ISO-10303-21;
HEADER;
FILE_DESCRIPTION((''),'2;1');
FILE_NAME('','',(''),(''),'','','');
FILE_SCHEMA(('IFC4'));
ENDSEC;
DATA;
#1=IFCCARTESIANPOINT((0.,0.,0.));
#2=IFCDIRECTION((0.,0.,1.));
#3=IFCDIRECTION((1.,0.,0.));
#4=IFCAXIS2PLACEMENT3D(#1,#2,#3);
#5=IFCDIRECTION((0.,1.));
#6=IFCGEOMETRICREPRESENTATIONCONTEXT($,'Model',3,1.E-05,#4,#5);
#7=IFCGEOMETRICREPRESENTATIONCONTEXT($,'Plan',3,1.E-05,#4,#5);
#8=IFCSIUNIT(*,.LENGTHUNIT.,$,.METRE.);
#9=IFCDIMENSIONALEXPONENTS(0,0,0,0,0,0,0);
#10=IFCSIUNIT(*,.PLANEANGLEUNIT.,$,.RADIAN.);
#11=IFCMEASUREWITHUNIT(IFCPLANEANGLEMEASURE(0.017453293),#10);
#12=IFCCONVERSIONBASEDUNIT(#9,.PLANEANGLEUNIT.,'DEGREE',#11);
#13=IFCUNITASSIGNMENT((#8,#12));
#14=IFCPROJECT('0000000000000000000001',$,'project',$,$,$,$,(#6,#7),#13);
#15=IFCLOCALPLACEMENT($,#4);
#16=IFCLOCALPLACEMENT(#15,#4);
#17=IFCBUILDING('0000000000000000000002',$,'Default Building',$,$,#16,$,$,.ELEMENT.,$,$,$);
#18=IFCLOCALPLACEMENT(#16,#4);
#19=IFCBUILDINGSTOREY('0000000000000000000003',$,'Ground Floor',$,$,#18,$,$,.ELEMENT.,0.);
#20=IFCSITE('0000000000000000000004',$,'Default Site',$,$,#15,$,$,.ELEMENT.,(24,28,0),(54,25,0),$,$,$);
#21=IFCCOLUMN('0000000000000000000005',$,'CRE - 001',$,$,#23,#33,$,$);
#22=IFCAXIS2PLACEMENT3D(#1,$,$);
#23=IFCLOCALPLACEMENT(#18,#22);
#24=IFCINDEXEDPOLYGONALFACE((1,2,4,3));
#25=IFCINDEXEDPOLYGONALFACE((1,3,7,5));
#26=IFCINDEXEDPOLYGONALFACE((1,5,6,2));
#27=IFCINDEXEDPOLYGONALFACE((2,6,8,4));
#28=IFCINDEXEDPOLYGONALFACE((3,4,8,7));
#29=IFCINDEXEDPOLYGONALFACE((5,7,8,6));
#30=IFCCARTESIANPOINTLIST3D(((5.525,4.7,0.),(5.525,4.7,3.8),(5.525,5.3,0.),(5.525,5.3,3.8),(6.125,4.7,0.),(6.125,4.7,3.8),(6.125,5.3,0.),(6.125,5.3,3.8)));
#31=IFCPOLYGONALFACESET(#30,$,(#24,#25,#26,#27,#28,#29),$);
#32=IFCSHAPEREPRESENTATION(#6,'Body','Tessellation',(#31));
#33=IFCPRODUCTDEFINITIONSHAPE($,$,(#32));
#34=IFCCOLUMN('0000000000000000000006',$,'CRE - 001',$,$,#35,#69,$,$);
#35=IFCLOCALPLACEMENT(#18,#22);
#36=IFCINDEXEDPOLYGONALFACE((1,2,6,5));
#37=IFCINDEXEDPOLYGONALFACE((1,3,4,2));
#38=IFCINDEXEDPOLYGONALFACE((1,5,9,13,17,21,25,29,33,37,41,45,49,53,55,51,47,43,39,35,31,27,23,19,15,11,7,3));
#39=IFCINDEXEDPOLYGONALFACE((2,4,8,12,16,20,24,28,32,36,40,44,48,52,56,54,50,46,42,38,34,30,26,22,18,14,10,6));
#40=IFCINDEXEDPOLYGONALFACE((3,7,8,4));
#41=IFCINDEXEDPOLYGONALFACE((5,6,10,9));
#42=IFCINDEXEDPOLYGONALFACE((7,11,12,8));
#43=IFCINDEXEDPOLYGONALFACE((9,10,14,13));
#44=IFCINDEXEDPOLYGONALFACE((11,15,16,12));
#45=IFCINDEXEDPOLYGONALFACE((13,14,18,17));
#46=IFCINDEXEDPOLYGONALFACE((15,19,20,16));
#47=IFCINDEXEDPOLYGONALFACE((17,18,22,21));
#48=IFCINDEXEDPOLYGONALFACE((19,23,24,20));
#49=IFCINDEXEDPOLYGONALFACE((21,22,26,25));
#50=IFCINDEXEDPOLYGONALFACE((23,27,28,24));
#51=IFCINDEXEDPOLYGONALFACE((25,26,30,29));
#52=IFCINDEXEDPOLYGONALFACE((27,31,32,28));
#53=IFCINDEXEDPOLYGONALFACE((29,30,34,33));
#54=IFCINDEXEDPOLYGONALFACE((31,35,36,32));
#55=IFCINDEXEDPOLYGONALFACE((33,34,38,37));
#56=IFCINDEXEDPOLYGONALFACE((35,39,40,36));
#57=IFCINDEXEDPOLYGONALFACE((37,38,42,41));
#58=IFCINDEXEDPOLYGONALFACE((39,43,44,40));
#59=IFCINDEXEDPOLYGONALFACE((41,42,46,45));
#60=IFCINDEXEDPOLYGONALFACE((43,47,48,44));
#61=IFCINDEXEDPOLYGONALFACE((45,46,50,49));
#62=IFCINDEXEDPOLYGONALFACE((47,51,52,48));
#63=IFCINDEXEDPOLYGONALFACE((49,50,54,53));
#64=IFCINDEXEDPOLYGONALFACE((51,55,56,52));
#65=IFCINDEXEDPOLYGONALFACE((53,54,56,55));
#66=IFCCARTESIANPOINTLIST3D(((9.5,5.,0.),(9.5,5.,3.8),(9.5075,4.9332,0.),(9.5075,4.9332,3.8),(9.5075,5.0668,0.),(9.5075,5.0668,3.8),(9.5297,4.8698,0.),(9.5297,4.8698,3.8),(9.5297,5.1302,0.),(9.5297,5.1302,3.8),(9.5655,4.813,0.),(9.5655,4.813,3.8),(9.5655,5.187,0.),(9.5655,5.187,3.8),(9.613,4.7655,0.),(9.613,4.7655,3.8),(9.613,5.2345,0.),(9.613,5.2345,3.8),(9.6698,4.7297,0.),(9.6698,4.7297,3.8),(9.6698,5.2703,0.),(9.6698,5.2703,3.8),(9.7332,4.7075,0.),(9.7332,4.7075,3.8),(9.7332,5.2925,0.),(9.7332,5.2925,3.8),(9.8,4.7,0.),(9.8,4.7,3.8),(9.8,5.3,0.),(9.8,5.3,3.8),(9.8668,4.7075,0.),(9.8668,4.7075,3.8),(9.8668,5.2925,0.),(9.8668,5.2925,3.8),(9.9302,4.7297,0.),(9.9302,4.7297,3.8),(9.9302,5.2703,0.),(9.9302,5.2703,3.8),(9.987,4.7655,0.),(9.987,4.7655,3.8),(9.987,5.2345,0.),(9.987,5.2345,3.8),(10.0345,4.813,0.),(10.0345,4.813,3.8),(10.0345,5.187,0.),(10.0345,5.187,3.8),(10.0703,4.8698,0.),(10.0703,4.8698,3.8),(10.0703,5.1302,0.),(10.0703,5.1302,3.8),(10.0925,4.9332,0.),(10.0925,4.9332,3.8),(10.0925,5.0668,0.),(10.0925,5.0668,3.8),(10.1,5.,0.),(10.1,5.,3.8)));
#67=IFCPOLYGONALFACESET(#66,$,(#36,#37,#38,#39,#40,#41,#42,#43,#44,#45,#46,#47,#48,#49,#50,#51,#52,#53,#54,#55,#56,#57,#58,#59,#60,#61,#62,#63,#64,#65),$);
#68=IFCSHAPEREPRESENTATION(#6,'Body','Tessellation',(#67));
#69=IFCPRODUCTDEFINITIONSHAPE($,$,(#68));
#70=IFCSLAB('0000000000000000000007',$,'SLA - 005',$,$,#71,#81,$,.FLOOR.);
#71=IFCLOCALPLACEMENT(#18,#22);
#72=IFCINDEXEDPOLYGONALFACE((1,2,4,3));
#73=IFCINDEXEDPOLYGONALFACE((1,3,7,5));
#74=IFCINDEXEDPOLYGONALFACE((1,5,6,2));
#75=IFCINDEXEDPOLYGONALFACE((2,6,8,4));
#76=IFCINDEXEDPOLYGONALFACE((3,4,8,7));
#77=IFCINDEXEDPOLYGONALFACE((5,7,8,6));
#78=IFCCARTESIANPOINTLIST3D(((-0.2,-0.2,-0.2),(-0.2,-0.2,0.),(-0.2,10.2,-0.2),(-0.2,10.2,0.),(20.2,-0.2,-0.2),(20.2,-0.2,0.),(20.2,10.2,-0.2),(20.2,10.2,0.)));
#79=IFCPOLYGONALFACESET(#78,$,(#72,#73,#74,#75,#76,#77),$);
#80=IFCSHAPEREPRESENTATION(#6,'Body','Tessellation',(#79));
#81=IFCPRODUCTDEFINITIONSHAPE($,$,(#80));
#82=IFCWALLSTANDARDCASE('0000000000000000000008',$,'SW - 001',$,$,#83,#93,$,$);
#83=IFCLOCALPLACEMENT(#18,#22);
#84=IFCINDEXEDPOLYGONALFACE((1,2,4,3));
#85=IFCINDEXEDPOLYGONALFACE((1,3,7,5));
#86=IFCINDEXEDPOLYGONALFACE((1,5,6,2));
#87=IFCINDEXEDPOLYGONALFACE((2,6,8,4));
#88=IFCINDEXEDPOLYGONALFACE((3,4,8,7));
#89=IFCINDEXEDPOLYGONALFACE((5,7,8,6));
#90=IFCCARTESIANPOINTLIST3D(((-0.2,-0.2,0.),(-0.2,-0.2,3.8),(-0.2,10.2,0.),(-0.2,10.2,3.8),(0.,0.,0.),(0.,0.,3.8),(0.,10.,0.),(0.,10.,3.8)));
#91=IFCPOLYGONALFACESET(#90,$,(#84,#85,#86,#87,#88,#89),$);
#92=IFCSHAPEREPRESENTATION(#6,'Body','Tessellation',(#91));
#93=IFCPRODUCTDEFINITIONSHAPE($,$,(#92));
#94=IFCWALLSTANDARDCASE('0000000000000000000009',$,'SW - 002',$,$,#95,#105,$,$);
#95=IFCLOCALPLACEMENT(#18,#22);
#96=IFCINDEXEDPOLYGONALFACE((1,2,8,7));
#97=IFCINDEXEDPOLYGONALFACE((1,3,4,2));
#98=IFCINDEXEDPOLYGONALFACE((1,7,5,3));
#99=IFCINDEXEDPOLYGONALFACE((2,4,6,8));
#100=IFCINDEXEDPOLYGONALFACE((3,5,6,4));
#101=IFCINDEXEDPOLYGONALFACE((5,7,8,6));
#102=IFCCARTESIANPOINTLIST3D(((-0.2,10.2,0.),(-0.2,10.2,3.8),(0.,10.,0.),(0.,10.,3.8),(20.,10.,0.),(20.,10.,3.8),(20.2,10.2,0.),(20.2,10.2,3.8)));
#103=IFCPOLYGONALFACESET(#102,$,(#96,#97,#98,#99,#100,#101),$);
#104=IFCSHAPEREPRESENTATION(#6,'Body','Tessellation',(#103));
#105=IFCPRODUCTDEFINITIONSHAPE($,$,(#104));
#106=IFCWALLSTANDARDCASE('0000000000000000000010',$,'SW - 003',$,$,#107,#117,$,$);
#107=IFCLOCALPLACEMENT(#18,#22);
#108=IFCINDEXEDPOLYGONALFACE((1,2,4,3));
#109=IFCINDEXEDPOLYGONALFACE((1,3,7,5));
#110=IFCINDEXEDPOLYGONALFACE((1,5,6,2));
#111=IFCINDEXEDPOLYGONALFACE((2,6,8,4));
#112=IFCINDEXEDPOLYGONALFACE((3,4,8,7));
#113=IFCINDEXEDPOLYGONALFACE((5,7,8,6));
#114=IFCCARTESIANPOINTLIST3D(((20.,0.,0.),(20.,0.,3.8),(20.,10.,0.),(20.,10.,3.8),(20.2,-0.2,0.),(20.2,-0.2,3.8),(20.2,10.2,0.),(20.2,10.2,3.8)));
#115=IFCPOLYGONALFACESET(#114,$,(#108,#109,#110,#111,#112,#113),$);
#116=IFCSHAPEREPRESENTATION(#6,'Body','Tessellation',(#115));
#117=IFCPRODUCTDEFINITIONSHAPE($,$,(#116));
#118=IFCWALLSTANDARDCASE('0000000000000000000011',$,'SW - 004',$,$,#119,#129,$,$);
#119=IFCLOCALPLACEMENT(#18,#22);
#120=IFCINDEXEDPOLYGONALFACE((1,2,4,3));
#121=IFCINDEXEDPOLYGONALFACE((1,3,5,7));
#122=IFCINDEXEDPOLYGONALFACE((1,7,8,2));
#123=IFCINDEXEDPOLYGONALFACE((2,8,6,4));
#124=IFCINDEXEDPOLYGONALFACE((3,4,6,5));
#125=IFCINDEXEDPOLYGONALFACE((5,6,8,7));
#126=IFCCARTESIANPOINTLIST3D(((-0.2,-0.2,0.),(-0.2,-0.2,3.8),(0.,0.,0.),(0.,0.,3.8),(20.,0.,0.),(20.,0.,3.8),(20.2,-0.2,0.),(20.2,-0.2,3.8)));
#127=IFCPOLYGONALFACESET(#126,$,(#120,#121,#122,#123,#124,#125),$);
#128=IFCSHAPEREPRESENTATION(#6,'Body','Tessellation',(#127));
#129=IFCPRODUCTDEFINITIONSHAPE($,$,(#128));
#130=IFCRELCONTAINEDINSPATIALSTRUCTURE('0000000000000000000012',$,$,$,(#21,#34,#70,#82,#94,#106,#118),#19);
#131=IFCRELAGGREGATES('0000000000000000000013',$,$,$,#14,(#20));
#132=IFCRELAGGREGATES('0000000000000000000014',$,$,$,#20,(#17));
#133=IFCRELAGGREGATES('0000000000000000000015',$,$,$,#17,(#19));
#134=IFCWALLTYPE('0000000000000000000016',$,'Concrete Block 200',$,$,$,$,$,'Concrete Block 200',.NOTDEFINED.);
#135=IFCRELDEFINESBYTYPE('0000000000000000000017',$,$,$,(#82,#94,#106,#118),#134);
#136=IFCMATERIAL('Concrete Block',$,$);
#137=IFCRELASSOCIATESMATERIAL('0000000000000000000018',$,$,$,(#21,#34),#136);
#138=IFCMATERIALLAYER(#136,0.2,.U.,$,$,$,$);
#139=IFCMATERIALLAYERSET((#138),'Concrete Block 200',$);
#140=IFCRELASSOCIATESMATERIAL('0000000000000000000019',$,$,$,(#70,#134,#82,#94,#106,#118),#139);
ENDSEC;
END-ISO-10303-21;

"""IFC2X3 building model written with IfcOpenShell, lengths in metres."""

from ifc_helpers import new_model, entity, si_unit, converted_unit, direction, frame, origin_with_axes, origin_2d_with_axis, place, context, project, spatial, polyline, rectangle, circle, outline, extrude, material, layer, layer_set, layer_usage, type_object, element, save


model = new_model("IFC2X3")

# Units and contexts
model_context = context("Model", 3, precision=1e-05, world=origin_with_axes(), true_north=direction((0.0, 1.0)))
plan_context = context("Plan", 3, precision=1e-05, world=origin_with_axes(), true_north=direction((0.0, 1.0)))
ifc_project = project(units=[si_unit("LENGTHUNIT", "METRE"), converted_unit("PLANEANGLEUNIT", "DEGREE", entity("IfcPlaneAngleMeasure", 0.017453293), si_unit("PLANEANGLEUNIT", "RADIAN"), dimensions=[0, 0, 0, 0, 0, 0, 0])], contexts=[model_context, plan_context])

# Site, building, storey
site_placement = place(None, origin_with_axes())
site = spatial("IfcSite", under=ifc_project, at=site_placement, Name="Default Site", CompositionType="ELEMENT", RefLatitude=(24, 28, 0), RefLongitude=(54, 25, 0))
building_placement = place(site_placement, origin_with_axes())
building = spatial("IfcBuilding", under=site, at=building_placement, Name="Default Building", CompositionType="ELEMENT")
storey_placement = place(building_placement, origin_with_axes())
storey = spatial("IfcBuildingStorey", under=building, at=storey_placement, Name="Ground Floor", CompositionType="ELEMENT", Elevation=0.0)

# Columns
ifc_material = material(Name="Concrete Block")
column_1_placement = place(storey_placement, frame((5.825, 5.0, 0.0), z_axis=(0.0, 0.0, 1.0), x_axis=(1.0, 0.0, 0.0)))
element("IfcColumn", 1, at=column_1_placement, inside=storey, material=ifc_material, Name="CRE - 001", context=model_context, shape_type="SweptSolid", body=[
    extrude(rectangle(XDim=0.6, YDim=0.6, at=origin_2d_with_axis()), origin_with_axes(), (0.0, 0.0, 1.0), 3.8),
])
column_2_placement = place(storey_placement, frame((9.8, 5.0, 0.0), z_axis=(0.0, 0.0, 1.0), x_axis=(1.0, 0.0, 0.0)))
element("IfcColumn", 2, at=column_2_placement, inside=storey, material=ifc_material, Name="CRE - 001", context=model_context, shape_type="SweptSolid", body=[
    extrude(circle(Radius=0.3, at=origin_2d_with_axis()), origin_with_axes(), (0.0, 0.0, 1.0), 3.8),
])

# Slab
ifc_layer = layer(ifc_material, 0.2, ventilated="UNKNOWN")
ifc_layer_set = layer_set([ifc_layer], Name="Concrete Block 200")
ifc_layer_usage_1 = layer_usage(ifc_layer_set, "AXIS3", "NEGATIVE", 0.2)
slab_placement = place(storey_placement, frame((-0.2, 10.2, -0.2), z_axis=(0.0, 0.0, 1.0), x_axis=(1.0, 0.0, 0.0)))
element("IfcSlab", 3, at=slab_placement, inside=storey, material=ifc_layer_usage_1, Name="SLA - 005", PredefinedType="FLOOR", context=model_context, shape_type="SweptSolid", body=[
    extrude(outline(polyline([(0.0, 0.0), (20.4, 0.0), (20.4, -10.4), (0.0, -10.4), (0.0, 0.0)])), origin_with_axes(), (0.0, 0.0, 1.0), 0.2),
])

# Walls
ifc_layer_usage_2 = layer_usage(ifc_layer_set, "AXIS2", "POSITIVE", 0.0)
wall_type = type_object("IfcWallType", Name="Concrete Block 200", ElementType="Concrete Block 200", PredefinedType="NOTDEFINED", material=ifc_layer_set)
wall_1_placement = place(storey_placement, frame((0.0, 0.0, 0.0), z_axis=(0.0, 0.0, 1.0), x_axis=(0.0, 1.0, 0.0)))
element("IfcWallStandardCase", 4, at=wall_1_placement, inside=storey, type_object=wall_type, material=ifc_layer_usage_2, Name="SW - 001", context=model_context, shape_type="SweptSolid", body=[
    extrude(outline(polyline([(0.0, 0.0), (10.0, 0.0), (10.2, 0.2), (-0.2, 0.2), (0.0, 0.0)])), origin_with_axes(), (0.0, 0.0, 1.0), 3.8),
])
ifc_layer_usage_3 = layer_usage(ifc_layer_set, "AXIS2", "POSITIVE", 0.0)
wall_2_placement = place(storey_placement, frame((0.0, 10.0, 0.0), z_axis=(0.0, 0.0, 1.0), x_axis=(1.0, 0.0, 0.0)))
element("IfcWallStandardCase", 5, at=wall_2_placement, inside=storey, type_object=wall_type, material=ifc_layer_usage_3, Name="SW - 002", context=model_context, shape_type="SweptSolid", body=[
    extrude(outline(polyline([(0.0, 0.0), (20.0, 0.0), (20.2, 0.2), (-0.2, 0.2), (0.0, 0.0)])), origin_with_axes(), (0.0, 0.0, 1.0), 3.8),
])
ifc_layer_usage_4 = layer_usage(ifc_layer_set, "AXIS2", "POSITIVE", 0.0)
wall_3_placement = place(storey_placement, frame((20.0, 10.0, 0.0), z_axis=(0.0, 0.0, 1.0), x_axis=(0.0, -1.0, 0.0)))
element("IfcWallStandardCase", 6, at=wall_3_placement, inside=storey, type_object=wall_type, material=ifc_layer_usage_4, Name="SW - 003", context=model_context, shape_type="SweptSolid", body=[
    extrude(outline(polyline([(0.0, 0.0), (10.0, 0.0), (10.2, 0.2), (-0.2, 0.2), (0.0, 0.0)])), origin_with_axes(), (0.0, 0.0, 1.0), 3.8),
])
ifc_layer_usage_5 = layer_usage(ifc_layer_set, "AXIS2", "POSITIVE", 0.0)
wall_4_placement = place(storey_placement, frame((20.0, 0.0, 0.0), z_axis=(0.0, 0.0, 1.0), x_axis=(-1.0, 0.0, 0.0)))
element("IfcWallStandardCase", 7, at=wall_4_placement, inside=storey, type_object=wall_type, material=ifc_layer_usage_5, Name="SW - 004", context=model_context, shape_type="SweptSolid", body=[
    extrude(outline(polyline([(0.0, 0.0), (20.0, 0.0), (20.2, 0.2), (-0.2, 0.2), (0.0, 0.0)])), origin_with_axes(), (0.0, 0.0, 1.0), 3.8),
])

save(model, "model.ifc")
